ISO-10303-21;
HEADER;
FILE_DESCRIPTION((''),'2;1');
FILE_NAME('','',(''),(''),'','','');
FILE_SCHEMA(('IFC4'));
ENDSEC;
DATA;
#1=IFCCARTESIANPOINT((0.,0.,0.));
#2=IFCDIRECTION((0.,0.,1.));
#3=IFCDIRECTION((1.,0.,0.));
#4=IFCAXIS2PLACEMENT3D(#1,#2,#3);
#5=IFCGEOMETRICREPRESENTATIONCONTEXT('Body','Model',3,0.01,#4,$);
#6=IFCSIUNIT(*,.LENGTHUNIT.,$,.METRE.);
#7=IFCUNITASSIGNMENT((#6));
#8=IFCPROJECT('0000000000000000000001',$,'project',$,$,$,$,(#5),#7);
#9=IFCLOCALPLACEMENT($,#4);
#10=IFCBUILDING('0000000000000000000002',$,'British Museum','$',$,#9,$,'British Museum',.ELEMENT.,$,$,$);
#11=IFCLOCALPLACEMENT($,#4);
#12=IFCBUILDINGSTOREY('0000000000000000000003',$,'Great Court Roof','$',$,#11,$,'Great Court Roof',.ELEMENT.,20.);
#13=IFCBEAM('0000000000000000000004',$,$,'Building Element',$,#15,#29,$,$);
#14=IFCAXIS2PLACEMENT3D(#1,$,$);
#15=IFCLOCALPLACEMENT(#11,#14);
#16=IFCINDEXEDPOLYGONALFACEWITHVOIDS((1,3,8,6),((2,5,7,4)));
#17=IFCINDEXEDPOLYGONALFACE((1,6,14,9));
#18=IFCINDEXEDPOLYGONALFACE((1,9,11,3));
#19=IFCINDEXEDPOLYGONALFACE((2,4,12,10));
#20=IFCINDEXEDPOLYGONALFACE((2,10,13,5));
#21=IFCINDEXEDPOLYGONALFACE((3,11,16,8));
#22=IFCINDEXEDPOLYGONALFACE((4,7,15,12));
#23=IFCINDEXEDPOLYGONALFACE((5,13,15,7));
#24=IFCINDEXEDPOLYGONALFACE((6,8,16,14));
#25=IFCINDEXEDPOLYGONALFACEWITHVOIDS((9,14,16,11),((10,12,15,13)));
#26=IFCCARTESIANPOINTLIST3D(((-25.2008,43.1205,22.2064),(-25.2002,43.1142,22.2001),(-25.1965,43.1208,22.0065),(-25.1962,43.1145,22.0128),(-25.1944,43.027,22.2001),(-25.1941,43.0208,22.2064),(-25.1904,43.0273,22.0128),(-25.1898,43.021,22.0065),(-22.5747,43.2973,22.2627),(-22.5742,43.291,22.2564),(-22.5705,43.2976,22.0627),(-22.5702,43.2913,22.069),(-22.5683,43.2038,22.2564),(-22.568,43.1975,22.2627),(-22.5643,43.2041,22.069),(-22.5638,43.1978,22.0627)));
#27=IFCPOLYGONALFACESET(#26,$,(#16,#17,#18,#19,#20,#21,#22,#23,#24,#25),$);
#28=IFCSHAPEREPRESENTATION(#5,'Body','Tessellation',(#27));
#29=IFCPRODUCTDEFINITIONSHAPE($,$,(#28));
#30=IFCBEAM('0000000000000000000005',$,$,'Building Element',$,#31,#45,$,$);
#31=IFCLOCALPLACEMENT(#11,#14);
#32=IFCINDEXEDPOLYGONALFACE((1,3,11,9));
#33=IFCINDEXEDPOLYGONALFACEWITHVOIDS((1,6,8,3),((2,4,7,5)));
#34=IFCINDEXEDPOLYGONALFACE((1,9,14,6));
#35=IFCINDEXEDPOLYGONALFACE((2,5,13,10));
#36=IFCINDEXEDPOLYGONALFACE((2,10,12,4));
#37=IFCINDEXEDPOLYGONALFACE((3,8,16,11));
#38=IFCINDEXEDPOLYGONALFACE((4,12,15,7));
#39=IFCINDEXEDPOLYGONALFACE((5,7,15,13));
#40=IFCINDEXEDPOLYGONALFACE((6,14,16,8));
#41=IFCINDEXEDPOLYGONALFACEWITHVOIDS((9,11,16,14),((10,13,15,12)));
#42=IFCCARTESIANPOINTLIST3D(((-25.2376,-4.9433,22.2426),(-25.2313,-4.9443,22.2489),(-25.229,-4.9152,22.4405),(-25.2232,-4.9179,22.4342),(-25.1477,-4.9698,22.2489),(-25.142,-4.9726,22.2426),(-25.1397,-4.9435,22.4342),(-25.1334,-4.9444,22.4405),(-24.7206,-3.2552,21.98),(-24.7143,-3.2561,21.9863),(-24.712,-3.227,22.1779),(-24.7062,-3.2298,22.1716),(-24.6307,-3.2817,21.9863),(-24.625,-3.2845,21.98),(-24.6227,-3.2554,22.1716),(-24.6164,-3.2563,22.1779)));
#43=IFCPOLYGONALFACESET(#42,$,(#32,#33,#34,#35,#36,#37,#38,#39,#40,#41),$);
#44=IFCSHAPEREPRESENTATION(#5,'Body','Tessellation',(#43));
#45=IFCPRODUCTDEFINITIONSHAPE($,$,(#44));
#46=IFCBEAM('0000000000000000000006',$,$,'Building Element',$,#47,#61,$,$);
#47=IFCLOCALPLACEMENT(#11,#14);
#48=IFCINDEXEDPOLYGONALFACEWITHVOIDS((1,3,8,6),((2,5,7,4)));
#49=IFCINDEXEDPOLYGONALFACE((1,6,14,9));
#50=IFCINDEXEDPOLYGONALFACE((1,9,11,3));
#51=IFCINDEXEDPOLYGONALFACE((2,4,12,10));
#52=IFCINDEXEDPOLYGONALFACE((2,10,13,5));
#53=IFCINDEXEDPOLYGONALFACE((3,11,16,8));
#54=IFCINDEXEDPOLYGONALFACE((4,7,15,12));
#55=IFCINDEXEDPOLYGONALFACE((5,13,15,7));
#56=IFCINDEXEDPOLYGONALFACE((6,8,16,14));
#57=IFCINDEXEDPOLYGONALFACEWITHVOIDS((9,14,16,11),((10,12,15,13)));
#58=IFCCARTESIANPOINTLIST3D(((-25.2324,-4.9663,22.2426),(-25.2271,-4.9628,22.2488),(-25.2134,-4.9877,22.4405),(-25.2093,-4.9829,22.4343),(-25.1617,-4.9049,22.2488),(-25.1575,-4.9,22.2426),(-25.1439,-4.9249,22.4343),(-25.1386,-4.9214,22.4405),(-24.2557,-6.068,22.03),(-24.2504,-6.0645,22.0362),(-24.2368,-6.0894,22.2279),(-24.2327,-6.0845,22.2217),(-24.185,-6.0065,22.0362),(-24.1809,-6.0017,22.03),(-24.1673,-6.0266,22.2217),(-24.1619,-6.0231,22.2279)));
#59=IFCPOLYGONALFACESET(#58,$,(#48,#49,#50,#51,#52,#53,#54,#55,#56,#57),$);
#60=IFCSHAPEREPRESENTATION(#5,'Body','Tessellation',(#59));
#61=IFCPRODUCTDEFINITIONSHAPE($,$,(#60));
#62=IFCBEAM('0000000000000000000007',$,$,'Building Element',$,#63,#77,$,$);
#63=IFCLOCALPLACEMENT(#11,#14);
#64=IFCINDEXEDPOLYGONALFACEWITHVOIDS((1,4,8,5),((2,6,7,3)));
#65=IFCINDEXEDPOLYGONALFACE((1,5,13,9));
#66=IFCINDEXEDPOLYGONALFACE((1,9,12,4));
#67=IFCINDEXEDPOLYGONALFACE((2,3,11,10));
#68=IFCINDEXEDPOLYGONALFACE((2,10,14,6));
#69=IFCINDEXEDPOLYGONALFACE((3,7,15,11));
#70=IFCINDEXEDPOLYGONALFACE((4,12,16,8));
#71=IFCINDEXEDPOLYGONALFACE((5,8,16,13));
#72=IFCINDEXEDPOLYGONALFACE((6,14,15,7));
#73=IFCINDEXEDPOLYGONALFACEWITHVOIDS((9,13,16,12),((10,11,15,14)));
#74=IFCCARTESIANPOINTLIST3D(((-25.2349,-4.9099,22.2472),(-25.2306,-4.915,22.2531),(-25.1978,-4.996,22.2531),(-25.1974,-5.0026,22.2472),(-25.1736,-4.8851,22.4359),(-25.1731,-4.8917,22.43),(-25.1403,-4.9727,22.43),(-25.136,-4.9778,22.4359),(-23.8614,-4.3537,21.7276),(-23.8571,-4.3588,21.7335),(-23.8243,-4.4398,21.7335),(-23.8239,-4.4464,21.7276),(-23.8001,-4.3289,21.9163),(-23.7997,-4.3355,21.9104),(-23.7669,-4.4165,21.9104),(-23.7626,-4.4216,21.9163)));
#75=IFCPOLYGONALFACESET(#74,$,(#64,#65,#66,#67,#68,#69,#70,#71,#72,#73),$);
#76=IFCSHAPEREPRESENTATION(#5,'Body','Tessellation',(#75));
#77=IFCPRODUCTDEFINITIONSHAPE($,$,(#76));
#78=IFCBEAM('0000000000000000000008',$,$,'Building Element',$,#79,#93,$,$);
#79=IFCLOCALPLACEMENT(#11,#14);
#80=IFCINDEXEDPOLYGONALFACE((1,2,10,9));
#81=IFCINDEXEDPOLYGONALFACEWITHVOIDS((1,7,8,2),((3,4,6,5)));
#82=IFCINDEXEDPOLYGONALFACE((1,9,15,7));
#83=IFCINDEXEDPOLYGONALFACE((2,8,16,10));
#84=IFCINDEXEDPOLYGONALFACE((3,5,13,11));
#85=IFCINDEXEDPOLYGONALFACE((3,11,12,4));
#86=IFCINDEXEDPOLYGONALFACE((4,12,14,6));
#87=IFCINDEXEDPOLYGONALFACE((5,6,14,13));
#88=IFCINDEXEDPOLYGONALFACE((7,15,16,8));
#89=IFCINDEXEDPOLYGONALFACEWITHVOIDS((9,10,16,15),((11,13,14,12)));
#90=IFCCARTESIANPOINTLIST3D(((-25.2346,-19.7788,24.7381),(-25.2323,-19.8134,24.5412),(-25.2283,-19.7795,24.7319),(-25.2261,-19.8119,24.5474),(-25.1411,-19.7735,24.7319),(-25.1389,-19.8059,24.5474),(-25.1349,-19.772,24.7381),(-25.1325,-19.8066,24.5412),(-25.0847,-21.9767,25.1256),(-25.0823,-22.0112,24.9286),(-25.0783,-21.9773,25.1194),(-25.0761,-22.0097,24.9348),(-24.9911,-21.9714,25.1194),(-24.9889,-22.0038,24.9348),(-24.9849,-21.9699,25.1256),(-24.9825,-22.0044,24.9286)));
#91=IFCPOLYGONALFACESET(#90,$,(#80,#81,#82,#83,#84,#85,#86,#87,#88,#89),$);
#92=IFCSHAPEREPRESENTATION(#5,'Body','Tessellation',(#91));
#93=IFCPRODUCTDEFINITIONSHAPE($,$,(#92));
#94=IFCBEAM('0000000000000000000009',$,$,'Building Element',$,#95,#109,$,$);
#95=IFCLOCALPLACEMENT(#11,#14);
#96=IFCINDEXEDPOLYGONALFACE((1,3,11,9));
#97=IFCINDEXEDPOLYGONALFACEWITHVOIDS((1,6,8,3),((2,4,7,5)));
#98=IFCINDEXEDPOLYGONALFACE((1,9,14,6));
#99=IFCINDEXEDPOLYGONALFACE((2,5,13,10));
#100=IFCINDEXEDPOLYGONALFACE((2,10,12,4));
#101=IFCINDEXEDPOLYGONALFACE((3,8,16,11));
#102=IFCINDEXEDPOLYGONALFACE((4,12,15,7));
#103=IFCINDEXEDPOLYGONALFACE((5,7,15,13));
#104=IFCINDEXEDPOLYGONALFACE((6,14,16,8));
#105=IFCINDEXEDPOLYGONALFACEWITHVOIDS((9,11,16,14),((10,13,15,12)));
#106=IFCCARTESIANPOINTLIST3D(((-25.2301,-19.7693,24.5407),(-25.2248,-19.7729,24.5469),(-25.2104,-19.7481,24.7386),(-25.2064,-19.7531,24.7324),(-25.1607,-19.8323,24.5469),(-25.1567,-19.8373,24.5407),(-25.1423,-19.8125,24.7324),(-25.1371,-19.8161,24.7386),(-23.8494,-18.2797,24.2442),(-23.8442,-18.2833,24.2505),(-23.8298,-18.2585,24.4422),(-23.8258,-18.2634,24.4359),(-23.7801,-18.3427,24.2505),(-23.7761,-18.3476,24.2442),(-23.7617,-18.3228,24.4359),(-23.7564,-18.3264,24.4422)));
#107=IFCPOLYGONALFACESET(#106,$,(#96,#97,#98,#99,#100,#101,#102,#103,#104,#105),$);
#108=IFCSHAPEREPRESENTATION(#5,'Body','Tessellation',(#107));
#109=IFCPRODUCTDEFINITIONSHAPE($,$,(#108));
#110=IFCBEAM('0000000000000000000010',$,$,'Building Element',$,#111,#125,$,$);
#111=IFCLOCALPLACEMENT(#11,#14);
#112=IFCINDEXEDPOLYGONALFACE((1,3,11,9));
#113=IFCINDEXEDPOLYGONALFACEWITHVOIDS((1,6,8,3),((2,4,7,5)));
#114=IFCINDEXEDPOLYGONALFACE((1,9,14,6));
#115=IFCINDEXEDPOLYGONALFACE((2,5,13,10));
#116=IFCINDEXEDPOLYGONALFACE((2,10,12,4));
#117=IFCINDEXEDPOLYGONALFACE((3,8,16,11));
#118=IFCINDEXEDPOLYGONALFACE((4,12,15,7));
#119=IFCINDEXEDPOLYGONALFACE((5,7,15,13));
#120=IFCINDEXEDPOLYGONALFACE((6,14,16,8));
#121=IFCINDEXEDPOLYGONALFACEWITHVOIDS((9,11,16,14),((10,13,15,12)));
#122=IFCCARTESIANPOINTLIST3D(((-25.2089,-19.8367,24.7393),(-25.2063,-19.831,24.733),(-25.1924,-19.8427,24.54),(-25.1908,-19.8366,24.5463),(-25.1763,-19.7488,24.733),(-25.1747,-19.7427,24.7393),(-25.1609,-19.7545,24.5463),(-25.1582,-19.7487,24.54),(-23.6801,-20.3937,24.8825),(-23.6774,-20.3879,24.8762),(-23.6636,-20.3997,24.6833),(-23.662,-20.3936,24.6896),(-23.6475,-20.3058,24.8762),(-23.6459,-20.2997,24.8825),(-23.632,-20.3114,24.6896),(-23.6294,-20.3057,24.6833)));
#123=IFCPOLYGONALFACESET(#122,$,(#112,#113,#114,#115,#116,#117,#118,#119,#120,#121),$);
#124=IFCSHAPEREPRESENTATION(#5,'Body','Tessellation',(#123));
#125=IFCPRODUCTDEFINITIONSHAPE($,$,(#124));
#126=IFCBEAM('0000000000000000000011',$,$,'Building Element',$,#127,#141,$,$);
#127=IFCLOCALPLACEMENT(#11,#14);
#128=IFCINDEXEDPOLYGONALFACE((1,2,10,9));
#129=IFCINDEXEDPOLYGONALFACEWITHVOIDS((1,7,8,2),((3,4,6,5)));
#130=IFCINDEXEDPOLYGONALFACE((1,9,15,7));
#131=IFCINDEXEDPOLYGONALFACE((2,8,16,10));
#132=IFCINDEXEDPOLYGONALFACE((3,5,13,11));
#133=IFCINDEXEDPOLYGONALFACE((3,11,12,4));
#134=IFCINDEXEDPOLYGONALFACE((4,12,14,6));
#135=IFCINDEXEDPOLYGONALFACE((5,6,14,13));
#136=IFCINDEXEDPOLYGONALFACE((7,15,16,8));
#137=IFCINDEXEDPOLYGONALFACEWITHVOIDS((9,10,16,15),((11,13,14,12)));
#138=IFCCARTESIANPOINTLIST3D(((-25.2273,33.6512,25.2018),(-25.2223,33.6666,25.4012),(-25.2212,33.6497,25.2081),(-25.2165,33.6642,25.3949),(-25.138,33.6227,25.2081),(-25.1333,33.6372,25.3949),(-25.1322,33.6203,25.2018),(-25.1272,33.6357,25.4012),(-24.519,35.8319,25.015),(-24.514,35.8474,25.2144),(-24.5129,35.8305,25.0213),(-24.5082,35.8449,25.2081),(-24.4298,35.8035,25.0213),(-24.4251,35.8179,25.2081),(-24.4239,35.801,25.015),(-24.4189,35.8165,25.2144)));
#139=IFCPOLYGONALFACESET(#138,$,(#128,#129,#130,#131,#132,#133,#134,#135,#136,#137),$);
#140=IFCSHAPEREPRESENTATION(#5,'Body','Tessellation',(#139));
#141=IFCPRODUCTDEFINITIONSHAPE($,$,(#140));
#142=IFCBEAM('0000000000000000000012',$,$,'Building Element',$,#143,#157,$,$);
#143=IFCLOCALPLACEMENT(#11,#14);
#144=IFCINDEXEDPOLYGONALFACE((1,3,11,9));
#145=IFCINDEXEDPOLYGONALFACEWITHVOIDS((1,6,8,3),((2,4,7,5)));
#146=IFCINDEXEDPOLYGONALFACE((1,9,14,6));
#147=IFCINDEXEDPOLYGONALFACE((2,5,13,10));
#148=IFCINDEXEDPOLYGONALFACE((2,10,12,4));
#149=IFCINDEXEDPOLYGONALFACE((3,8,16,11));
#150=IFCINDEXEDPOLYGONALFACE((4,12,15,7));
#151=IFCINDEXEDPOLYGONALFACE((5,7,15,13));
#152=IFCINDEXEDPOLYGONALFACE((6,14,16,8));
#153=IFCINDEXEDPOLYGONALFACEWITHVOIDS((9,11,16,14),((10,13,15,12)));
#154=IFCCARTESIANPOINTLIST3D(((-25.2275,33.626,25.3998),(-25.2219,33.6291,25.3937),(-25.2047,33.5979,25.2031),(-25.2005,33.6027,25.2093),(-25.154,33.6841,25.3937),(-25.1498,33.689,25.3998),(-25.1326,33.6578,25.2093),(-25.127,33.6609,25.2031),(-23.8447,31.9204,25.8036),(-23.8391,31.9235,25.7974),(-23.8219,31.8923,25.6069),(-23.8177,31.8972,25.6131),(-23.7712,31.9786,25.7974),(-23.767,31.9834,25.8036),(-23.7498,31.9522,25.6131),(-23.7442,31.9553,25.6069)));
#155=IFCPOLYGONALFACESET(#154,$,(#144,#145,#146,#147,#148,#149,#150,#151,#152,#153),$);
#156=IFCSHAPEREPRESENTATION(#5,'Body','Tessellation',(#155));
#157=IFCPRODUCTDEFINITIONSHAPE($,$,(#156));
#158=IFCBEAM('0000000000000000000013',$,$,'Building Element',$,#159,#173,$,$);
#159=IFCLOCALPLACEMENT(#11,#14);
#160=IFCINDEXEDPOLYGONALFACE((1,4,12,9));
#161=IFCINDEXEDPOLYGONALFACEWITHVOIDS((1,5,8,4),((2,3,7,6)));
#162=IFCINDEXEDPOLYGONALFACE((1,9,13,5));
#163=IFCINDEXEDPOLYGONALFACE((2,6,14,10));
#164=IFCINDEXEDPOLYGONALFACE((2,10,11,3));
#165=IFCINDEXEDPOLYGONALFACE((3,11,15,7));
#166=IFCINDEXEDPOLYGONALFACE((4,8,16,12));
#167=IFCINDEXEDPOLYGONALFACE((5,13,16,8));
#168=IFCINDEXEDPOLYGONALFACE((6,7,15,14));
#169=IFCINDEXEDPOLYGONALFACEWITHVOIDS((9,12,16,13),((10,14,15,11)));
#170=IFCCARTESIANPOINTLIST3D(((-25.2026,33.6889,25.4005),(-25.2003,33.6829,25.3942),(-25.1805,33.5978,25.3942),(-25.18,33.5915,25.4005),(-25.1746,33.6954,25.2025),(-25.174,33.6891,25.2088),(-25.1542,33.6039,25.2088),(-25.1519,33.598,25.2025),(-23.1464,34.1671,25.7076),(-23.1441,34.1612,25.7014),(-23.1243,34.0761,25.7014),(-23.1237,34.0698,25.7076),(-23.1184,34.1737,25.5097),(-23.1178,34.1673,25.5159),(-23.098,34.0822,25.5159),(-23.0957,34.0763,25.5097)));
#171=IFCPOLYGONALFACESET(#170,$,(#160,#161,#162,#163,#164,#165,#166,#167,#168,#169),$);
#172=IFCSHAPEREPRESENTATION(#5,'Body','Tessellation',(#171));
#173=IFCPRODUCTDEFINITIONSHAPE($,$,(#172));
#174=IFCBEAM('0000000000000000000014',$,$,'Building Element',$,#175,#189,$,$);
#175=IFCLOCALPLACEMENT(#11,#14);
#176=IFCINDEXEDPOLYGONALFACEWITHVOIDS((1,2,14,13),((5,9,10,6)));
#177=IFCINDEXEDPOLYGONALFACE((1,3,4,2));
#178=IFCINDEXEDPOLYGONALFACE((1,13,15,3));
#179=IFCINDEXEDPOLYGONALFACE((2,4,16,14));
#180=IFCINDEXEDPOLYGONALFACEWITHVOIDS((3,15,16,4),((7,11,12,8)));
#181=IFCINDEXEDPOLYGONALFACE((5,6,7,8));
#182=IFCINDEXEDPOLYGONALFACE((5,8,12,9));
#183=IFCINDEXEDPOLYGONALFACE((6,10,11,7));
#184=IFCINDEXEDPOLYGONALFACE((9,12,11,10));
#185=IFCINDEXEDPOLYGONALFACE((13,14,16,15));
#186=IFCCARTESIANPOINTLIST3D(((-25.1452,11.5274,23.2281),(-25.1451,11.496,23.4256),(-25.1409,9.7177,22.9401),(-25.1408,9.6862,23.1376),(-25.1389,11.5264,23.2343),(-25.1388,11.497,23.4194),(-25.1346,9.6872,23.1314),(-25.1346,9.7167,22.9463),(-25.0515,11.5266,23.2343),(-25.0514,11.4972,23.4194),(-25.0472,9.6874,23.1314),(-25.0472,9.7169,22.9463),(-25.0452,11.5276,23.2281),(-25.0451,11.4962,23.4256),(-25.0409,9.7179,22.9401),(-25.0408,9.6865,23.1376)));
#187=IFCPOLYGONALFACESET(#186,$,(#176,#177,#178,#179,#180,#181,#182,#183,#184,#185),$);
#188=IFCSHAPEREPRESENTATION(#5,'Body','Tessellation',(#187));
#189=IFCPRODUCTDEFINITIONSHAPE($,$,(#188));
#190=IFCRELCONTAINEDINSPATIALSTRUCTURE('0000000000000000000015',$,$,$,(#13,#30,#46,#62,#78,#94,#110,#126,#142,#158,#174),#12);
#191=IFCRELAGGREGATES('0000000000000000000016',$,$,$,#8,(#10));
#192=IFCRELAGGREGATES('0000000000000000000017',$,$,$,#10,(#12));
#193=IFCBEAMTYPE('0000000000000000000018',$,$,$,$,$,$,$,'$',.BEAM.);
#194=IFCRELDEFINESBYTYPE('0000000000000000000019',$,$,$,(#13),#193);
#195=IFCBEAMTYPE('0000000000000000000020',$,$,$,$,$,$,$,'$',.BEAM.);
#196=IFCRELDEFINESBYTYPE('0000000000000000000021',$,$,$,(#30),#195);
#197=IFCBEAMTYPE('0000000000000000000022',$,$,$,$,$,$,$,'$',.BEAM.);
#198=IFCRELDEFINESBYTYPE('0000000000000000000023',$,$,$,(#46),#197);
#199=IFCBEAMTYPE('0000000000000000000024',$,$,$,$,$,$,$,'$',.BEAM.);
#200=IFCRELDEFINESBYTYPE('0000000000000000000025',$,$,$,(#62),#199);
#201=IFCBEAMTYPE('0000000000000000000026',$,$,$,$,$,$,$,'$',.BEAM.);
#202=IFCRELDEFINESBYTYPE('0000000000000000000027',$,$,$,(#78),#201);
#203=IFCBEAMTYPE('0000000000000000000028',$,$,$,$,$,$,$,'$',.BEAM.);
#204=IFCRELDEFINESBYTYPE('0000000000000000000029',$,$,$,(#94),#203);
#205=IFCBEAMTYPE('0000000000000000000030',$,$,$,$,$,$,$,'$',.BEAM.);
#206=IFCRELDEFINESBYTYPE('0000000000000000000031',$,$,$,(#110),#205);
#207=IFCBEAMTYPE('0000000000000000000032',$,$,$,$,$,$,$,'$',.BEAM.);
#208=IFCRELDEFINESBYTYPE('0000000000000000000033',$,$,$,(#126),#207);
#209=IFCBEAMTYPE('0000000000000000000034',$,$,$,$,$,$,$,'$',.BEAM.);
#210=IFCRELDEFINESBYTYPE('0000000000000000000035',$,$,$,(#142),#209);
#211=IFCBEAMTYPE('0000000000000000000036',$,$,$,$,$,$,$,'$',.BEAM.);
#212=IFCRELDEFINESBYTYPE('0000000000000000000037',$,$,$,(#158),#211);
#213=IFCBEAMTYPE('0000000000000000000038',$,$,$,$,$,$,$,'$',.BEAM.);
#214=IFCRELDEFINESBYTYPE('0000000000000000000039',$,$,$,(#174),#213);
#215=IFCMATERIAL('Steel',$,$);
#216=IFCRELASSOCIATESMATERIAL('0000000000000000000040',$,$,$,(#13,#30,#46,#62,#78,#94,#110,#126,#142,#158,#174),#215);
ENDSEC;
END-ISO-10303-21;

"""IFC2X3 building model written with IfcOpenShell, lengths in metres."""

from ifc_helpers import new_model, si_unit, frame, origin_with_axes, origin_2d, place, context, project, spatial, hollow_rectangle, extrude, material, type_object, element, save


model = new_model("IFC2X3")

# Units and contexts
model_context = context("Model", 3, precision=0.01, world=origin_with_axes(), identifier="Body")
ifc_project = project(units=[si_unit("LENGTHUNIT", "METRE")], contexts=[model_context])

# Building, storey
building_placement = place(None, origin_with_axes())
building = spatial("IfcBuilding", under=ifc_project, at=building_placement, Name="British Museum", Description="$", LongName="British Museum", CompositionType="ELEMENT")
storey_placement = place(None, origin_with_axes())
storey = spatial("IfcBuildingStorey", under=building, at=storey_placement, Name="Great Court Roof", Description="$", LongName="Great Court Roof", CompositionType="ELEMENT", Elevation=20.0)

# Beams
ifc_material = material(Name="Steel")
beam_type_1 = type_object("IfcBeamType", ElementType="$", PredefinedType="BEAM")
beam_1_placement = place(None, origin_with_axes())
element("IfcBeam", 1, at=beam_1_placement, inside=storey, type_object=beam_type_1, material=ifc_material, Description="Building Element", context=model_context, shape_type="SweptSolid", body=[
    extrude(hollow_rectangle(XDim=0.1, YDim=0.2, WallThickness=0.0063, InnerFilletRadius=0.0, OuterFilletRadius=0.0, at=origin_2d()), frame((-25.1953, 43.0708, 22.1065), z_axis=(0.997515, 0.067136, 0.021361), x_axis=(-0.067151, 0.997743, 0.0)), (0.0, 0.0, 1.0), 2.6326),
])
beam_type_2 = type_object("IfcBeamType", ElementType="$", PredefinedType="BEAM")
beam_2_placement = place(None, origin_with_axes())
element("IfcBeam", 2, at=beam_2_placement, inside=storey, type_object=beam_type_2, material=ifc_material, Description="Building Element", context=model_context, shape_type="SweptSolid", body=[
    extrude(hollow_rectangle(XDim=0.1, YDim=0.2, WallThickness=0.0063, InnerFilletRadius=0.0, OuterFilletRadius=0.0, at=origin_2d()), frame((-25.1855, -4.9439, 22.3415), z_axis=(0.289648, 0.945759, -0.147116), x_axis=(-0.956163, 0.292834, 0.0)), (0.0, 0.0, 1.0), 1.7849),
])
beam_type_3 = type_object("IfcBeamType", ElementType="$", PredefinedType="BEAM")
beam_3_placement = place(None, origin_with_axes())
element("IfcBeam", 3, at=beam_3_placement, inside=storey, type_object=beam_type_3, material=ifc_material, Description="Building Element", context=model_context, shape_type="SweptSolid", body=[
    extrude(hollow_rectangle(XDim=0.1, YDim=0.2, WallThickness=0.0063, InnerFilletRadius=0.0, OuterFilletRadius=0.0, at=origin_2d()), frame((-25.1855, -4.9439, 22.3415), z_axis=(0.656558, -0.740611, -0.142923), x_axis=(0.748293, 0.663368, 0.0)), (0.0, 0.0, 1.0), 1.4875),
])
beam_type_4 = type_object("IfcBeamType", ElementType="$", PredefinedType="BEAM")
beam_4_placement = place(None, origin_with_axes())
element("IfcBeam", 4, at=beam_4_placement, inside=storey, type_object=beam_type_4, material=ifc_material, Description="Building Element", context=model_context, shape_type="SweptSolid", body=[
    extrude(hollow_rectangle(XDim=0.1, YDim=0.2, WallThickness=0.0063, InnerFilletRadius=0.0, OuterFilletRadius=0.0, at=origin_2d()), frame((-25.1855, -4.9439, 22.3415), z_axis=(0.87467, 0.354208, -0.330891), x_axis=(-0.375352, 0.926882, 0.0)), (0.0, 0.0, 1.0), 1.5703),
])
beam_type_5 = type_object("IfcBeamType", ElementType="$", PredefinedType="BEAM")
beam_5_placement = place(None, origin_with_axes())
element("IfcBeam", 5, at=beam_5_placement, inside=storey, type_object=beam_type_5, material=ifc_material, Description="Building Element", context=model_context, shape_type="SweptSolid", body=[
    extrude(hollow_rectangle(XDim=0.1, YDim=0.2, WallThickness=0.0063, InnerFilletRadius=0.0, OuterFilletRadius=0.0, at=origin_2d()), frame((-25.1836, -19.7927, 24.6397), z_axis=(0.067051, -0.982599, 0.173213), x_axis=(0.99768, 0.06808, 0.0)), (0.0, 0.0, 1.0), 2.2368),
])
beam_type_6 = type_object("IfcBeamType", ElementType="$", PredefinedType="BEAM")
beam_6_placement = place(None, origin_with_axes())
element("IfcBeam", 6, at=beam_6_placement, inside=storey, type_object=beam_type_6, material=ifc_material, Description="Building Element", context=model_context, shape_type="SweptSolid", body=[
    extrude(hollow_rectangle(XDim=0.1, YDim=0.2, WallThickness=0.0063, InnerFilletRadius=0.0, OuterFilletRadius=0.0, at=origin_2d()), frame((-25.1836, -19.7927, 24.6397), z_axis=(0.672632, 0.725745, -0.144433), x_axis=(-0.733435, 0.679759, 0.0)), (0.0, 0.0, 1.0), 2.0526),
])
beam_type_7 = type_object("IfcBeamType", ElementType="$", PredefinedType="BEAM")
beam_7_placement = place(None, origin_with_axes())
element("IfcBeam", 7, at=beam_7_placement, inside=storey, type_object=beam_type_7, material=ifc_material, Description="Building Element", context=model_context, shape_type="SweptSolid", body=[
    extrude(hollow_rectangle(XDim=0.1, YDim=0.2, WallThickness=0.0063, InnerFilletRadius=0.0, OuterFilletRadius=0.0, at=origin_2d()), frame((-25.1836, -19.7927, 24.6397), z_axis=(0.93597, -0.340985, 0.08769), x_axis=(0.342304, 0.939589, 0.0)), (0.0, 0.0, 1.0), 1.6334),
])
beam_type_8 = type_object("IfcBeamType", ElementType="$", PredefinedType="BEAM")
beam_8_placement = place(None, origin_with_axes())
element("IfcBeam", 8, at=beam_8_placement, inside=storey, type_object=beam_type_8, material=ifc_material, Description="Building Element", context=model_context, shape_type="SweptSolid", body=[
    extrude(hollow_rectangle(XDim=0.1, YDim=0.2, WallThickness=0.0063, InnerFilletRadius=0.0, OuterFilletRadius=0.0, at=origin_2d()), frame((-25.1773, 33.6434, 25.3015), z_axis=(0.307883, 0.947954, -0.081192), x_axis=(-0.951094, 0.308902, 0.0)), (0.0, 0.0, 1.0), 2.3005),
])
beam_type_9 = type_object("IfcBeamType", ElementType="$", PredefinedType="BEAM")
beam_9_placement = place(None, origin_with_axes())
element("IfcBeam", 9, at=beam_9_placement, inside=storey, type_object=beam_type_9, material=ifc_material, Description="Building Element", context=model_context, shape_type="SweptSolid", body=[
    extrude(hollow_rectangle(XDim=0.1, YDim=0.2, WallThickness=0.0063, InnerFilletRadius=0.0, OuterFilletRadius=0.0, at=origin_2d()), frame((-25.1773, 33.6434, 25.3015), z_axis=(0.619393, -0.763965, 0.180858), x_axis=(0.776775, 0.629779, 0.0)), (0.0, 0.0, 1.0), 2.2325),
])
beam_type_10 = type_object("IfcBeamType", ElementType="$", PredefinedType="BEAM")
beam_10_placement = place(None, origin_with_axes())
element("IfcBeam", 10, at=beam_10_placement, inside=storey, type_object=beam_type_10, material=ifc_material, Description="Building Element", context=model_context, shape_type="SweptSolid", body=[
    extrude(hollow_rectangle(XDim=0.1, YDim=0.2, WallThickness=0.0063, InnerFilletRadius=0.0, OuterFilletRadius=0.0, at=origin_2d()), frame((-25.1773, 33.6434, 25.3015), z_axis=(0.96385, 0.224194, 0.143982), x_axis=(-0.226555, 0.973998, 0.0)), (0.0, 0.0, 1.0), 2.1333),
])
beam_type_11 = type_object("IfcBeamType", ElementType="$", PredefinedType="BEAM")
beam_11_placement = place(None, origin_with_axes())
element("IfcBeam", 11, at=beam_11_placement, inside=storey, type_object=beam_type_11, material=ifc_material, Description="Building Element", context=model_context, shape_type="SweptSolid", body=[
    extrude(hollow_rectangle(XDim=0.1, YDim=0.2, WallThickness=0.0063, InnerFilletRadius=0.0, OuterFilletRadius=0.0, at=origin_2d()), frame((-25.0951, 11.5118, 23.3269), z_axis=(0.002313, -0.987571, -0.157154), x_axis=(0.999997, 0.002342, 0.0)), (0.0, 0.0, 1.0), 1.8325),
])

save(model, "model.ifc")
